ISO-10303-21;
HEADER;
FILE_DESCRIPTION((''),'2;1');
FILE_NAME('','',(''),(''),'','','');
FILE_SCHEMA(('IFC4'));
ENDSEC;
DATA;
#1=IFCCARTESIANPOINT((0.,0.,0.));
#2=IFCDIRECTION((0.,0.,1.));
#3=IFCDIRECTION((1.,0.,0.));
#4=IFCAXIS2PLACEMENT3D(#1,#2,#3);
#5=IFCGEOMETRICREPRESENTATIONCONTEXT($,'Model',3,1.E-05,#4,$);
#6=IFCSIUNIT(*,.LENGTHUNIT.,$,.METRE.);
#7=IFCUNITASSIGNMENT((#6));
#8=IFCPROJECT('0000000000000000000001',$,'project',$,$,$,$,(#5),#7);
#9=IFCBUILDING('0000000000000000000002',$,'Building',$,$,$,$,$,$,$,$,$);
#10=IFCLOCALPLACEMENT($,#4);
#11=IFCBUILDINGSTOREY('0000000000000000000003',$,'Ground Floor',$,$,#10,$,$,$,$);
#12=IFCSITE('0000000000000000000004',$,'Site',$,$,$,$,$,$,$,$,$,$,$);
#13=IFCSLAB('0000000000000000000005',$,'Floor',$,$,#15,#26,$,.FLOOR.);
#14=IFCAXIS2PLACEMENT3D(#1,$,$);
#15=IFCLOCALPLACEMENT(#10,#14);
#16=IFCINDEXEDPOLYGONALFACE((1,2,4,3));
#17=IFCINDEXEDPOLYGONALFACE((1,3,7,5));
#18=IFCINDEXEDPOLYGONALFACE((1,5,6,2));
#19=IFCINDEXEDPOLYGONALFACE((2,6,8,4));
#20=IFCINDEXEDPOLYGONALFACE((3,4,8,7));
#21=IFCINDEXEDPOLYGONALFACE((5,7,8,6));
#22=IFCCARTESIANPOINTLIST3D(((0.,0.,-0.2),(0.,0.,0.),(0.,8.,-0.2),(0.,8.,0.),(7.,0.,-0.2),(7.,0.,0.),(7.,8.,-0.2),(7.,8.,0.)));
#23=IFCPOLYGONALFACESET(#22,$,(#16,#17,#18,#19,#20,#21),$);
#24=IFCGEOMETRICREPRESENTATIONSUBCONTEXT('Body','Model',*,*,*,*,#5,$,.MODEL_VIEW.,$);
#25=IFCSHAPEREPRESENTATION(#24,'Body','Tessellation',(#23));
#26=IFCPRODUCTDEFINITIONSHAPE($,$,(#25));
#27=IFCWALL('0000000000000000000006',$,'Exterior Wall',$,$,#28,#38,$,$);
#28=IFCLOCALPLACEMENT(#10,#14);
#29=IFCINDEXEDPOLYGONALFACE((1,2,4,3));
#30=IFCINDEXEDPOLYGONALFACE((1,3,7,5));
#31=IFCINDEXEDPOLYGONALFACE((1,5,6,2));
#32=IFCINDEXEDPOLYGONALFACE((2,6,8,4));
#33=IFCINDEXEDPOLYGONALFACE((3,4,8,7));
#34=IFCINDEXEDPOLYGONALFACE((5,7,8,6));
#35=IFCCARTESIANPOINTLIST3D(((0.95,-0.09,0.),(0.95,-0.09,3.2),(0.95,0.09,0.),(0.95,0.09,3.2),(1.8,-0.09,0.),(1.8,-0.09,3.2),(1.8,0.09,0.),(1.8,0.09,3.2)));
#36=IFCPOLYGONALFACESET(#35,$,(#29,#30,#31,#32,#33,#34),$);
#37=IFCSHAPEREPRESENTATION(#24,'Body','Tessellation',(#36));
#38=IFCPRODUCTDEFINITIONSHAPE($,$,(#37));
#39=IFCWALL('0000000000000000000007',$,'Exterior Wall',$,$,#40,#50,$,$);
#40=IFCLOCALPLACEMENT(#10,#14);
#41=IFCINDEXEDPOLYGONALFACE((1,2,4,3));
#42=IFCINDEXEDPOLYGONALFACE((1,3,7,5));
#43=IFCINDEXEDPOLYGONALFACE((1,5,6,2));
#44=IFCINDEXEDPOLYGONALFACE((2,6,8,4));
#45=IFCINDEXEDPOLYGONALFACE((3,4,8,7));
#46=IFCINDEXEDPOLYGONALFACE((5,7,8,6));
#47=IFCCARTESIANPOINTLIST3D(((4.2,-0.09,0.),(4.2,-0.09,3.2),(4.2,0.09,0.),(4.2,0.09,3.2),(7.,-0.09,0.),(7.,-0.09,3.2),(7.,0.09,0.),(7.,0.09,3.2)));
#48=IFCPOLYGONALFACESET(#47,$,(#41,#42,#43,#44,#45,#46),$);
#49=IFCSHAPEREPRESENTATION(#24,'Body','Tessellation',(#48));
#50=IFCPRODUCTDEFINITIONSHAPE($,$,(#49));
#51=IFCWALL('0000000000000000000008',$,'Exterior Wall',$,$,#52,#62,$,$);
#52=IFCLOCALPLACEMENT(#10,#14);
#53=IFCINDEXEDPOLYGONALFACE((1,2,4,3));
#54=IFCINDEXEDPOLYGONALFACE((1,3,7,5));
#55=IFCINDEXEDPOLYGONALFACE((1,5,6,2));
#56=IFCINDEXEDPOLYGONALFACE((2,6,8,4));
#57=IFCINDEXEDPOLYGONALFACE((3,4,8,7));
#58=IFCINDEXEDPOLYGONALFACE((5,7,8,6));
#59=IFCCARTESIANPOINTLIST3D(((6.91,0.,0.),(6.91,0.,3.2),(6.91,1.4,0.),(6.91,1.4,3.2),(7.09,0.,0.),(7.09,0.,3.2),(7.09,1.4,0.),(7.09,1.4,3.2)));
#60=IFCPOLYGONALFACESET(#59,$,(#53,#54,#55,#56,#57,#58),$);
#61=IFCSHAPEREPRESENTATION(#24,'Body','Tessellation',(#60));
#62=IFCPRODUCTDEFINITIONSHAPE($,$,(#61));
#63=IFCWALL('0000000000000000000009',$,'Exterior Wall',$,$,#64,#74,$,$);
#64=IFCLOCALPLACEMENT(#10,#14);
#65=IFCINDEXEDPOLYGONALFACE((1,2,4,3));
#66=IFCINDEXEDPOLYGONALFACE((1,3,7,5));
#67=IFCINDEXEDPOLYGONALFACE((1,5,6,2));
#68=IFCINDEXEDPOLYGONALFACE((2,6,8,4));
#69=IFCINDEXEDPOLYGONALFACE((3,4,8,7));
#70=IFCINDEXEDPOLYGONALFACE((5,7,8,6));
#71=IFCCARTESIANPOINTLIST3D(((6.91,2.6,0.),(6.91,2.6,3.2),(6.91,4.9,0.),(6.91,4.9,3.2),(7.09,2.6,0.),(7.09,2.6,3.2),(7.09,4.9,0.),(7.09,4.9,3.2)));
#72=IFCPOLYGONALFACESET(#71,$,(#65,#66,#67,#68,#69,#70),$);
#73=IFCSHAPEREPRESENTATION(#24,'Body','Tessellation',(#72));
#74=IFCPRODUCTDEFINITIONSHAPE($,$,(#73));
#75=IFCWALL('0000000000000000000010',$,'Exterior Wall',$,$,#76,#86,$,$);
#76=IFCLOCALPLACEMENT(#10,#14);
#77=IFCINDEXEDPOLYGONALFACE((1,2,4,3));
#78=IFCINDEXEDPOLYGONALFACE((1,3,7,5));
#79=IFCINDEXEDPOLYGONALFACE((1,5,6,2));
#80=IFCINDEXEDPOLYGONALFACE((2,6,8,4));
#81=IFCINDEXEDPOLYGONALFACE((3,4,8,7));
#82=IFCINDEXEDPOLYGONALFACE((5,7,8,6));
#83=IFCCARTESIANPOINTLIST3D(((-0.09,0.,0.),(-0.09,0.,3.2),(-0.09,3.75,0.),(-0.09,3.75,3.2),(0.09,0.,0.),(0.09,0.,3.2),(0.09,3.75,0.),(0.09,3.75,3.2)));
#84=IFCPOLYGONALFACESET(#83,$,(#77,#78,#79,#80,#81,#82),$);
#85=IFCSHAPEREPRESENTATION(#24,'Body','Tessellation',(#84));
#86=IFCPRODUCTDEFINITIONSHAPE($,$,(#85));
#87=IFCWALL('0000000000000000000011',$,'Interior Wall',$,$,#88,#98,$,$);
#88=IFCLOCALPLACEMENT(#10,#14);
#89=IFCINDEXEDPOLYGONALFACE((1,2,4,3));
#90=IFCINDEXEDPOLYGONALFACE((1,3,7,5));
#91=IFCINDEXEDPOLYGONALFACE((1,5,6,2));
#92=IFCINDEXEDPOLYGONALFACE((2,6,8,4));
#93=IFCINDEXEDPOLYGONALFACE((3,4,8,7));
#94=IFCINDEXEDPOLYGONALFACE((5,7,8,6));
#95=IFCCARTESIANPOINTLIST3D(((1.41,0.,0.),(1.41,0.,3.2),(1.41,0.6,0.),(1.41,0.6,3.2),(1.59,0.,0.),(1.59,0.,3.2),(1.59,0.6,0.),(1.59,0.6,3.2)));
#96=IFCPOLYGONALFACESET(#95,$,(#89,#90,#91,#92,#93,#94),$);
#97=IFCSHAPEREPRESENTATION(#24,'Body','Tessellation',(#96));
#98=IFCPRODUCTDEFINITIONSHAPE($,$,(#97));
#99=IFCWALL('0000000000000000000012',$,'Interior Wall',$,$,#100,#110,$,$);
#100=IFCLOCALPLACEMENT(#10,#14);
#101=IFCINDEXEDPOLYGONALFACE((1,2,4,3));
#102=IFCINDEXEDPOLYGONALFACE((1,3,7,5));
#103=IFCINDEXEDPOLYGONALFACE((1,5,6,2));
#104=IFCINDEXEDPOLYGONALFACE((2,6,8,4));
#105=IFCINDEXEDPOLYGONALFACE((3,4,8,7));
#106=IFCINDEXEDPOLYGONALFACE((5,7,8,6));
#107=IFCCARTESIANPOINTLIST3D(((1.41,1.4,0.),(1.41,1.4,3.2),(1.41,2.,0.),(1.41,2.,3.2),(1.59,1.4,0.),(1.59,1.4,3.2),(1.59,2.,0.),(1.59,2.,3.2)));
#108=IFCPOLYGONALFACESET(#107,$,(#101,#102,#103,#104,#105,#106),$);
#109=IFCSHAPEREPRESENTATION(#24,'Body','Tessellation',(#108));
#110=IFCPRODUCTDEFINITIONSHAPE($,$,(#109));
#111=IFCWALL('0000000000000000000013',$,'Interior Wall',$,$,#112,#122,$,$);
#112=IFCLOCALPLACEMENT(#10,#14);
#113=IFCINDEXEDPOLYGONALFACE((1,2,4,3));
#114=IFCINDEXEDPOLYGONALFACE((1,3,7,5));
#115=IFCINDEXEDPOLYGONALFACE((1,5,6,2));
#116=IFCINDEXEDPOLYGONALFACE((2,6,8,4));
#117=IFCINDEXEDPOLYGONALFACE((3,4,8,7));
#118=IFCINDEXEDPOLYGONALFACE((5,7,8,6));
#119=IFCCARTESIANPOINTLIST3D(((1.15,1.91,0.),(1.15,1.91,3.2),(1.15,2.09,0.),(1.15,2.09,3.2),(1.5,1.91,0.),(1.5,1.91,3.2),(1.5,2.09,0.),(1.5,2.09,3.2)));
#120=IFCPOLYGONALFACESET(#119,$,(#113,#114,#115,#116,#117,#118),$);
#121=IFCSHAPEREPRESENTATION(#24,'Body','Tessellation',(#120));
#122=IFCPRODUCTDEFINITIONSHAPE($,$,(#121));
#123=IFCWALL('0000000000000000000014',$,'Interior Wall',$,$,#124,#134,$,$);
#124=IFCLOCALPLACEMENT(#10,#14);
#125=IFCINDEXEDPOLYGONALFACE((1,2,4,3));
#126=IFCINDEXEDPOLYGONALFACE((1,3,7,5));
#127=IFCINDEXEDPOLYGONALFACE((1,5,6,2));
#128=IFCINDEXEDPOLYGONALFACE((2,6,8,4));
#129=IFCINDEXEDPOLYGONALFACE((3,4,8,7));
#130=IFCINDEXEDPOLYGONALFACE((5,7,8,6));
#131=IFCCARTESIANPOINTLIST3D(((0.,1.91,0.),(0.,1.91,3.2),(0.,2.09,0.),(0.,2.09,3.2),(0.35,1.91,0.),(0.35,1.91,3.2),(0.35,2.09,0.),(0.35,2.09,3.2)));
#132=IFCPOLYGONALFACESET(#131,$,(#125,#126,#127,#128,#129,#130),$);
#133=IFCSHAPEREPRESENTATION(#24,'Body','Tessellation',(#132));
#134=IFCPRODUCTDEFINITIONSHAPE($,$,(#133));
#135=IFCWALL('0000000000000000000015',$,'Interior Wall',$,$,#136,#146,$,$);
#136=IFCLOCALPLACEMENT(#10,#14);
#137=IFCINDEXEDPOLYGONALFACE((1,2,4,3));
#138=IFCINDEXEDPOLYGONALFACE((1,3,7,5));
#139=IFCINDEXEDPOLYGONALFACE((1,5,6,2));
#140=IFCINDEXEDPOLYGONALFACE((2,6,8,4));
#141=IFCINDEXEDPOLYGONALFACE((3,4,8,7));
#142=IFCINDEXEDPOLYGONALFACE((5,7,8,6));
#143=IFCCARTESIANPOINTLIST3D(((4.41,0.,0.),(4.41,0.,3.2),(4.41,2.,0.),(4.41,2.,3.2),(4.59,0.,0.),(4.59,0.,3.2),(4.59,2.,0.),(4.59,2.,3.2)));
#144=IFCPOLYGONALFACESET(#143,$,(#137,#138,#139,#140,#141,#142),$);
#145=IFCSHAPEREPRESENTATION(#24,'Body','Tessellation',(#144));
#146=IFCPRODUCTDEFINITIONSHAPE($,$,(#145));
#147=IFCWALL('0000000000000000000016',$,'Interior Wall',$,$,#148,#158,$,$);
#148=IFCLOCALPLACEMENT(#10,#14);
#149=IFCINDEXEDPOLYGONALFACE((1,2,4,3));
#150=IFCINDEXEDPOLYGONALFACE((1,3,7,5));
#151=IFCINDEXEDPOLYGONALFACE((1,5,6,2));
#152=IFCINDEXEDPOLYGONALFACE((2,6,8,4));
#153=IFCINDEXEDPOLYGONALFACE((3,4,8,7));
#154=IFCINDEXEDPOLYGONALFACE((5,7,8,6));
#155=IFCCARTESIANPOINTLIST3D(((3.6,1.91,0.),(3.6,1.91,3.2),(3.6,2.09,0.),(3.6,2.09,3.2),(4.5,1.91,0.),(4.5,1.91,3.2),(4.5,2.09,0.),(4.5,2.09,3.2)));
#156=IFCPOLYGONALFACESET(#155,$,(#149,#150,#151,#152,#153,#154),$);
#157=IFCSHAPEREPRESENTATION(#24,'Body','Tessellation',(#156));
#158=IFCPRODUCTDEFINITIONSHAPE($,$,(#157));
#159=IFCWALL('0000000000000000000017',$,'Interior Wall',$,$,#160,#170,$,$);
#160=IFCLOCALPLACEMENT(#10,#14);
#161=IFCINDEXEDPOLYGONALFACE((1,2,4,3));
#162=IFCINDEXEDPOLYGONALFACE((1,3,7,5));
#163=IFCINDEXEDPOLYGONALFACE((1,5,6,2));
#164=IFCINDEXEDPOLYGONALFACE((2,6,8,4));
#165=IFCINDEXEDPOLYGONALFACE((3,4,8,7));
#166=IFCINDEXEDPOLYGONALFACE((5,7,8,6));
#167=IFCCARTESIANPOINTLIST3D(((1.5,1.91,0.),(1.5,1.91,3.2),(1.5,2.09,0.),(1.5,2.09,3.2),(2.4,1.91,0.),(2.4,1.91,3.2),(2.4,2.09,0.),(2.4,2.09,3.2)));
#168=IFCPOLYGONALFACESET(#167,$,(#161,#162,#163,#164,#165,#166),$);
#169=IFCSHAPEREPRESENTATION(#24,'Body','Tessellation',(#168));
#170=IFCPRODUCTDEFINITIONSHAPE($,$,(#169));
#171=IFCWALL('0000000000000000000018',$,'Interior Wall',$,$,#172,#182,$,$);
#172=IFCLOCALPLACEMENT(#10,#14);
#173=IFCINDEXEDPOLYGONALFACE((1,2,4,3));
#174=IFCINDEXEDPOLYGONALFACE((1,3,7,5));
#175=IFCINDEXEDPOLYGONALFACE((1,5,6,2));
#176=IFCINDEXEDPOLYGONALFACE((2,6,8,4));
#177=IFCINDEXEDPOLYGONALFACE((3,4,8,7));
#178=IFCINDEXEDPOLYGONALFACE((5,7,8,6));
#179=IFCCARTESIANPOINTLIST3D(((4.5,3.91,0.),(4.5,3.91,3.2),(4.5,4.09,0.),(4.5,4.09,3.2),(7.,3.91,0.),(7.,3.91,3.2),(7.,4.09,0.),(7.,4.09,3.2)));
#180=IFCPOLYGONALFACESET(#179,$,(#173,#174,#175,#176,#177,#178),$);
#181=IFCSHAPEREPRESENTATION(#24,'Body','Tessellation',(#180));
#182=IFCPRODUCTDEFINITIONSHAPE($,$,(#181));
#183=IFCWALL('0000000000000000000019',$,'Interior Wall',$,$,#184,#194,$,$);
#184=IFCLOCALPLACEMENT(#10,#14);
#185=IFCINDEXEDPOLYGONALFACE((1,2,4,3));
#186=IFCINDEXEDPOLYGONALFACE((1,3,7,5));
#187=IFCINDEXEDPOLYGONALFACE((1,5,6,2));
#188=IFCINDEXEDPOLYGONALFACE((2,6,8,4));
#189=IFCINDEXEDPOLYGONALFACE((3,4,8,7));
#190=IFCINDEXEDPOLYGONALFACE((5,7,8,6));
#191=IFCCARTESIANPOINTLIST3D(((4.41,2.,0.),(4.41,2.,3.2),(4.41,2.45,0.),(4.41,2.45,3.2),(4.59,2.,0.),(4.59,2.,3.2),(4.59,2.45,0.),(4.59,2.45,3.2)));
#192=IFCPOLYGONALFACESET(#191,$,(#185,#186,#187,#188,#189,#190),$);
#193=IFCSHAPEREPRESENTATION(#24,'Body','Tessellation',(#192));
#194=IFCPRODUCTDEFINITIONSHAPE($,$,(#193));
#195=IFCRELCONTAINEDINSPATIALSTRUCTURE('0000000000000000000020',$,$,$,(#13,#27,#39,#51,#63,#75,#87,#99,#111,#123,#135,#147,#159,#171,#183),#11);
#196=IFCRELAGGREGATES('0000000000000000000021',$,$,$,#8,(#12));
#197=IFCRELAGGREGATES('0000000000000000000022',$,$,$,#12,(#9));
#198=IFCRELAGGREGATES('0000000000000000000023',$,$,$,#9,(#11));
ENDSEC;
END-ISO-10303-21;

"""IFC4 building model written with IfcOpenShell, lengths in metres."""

from ifc_helpers import new_model, si_unit, frame, origin_with_axes, place, context, subcontext, project, spatial, indexed_curve, outline, extrude, element, save


model = new_model("IFC4")

# Units and contexts
model_context = context("Model", 3, precision=1e-05, world=origin_with_axes())
body_context = subcontext(model_context, "Body", "Model", "MODEL_VIEW")
ifc_project = project(units=[si_unit("LENGTHUNIT", "METRE")], contexts=[model_context])

# Site, building, storey
site = spatial("IfcSite", under=ifc_project, Name="Site")
building = spatial("IfcBuilding", under=site, Name="Building")
storey_placement = place(None, origin_with_axes())
storey = spatial("IfcBuildingStorey", under=building, at=storey_placement, Name="Ground Floor")

# Slab
slab_placement = place(storey_placement, frame((0.0, 0.0, -0.2), z_axis=(0.0, 0.0, 1.0), x_axis=(1.0, 0.0, 0.0)))
element("IfcSlab", 1, at=slab_placement, inside=storey, Name="Floor", PredefinedType="FLOOR", context=body_context, shape_type="SweptSolid", body=[
    extrude(outline(indexed_curve([(0.0, 0.0), (7.0, 0.0), (7.0, 8.0), (0.0, 8.0)])), None, (0.0, 0.0, 1.0), 0.2),
])

# Walls
wall_1_placement = place(storey_placement, frame((0.95, 0.0, 0.0), z_axis=(0.0, 0.0, 1.0), x_axis=(1.0, 0.0, 0.0)))
element("IfcWall", 2, at=wall_1_placement, inside=storey, Name="Exterior Wall", context=body_context, shape_type="SweptSolid", body=[
    extrude(outline(indexed_curve([(0.0, 0.0), (0.0, 0.18), (0.85, 0.18), (0.85, 0.0), (0.0, 0.0)], self_intersect=False)), frame((0.0, -0.09, 0.0), z_axis=(0.0, 0.0, 1.0), x_axis=(1.0, 0.0, 0.0)), (0.0, 0.0, 1.0), 3.2),
])
wall_2_placement = place(storey_placement, frame((4.2, 0.0, 0.0), z_axis=(0.0, 0.0, 1.0), x_axis=(1.0, 0.0, 0.0)))
element("IfcWall", 3, at=wall_2_placement, inside=storey, Name="Exterior Wall", context=body_context, shape_type="SweptSolid", body=[
    extrude(outline(indexed_curve([(0.0, 0.0), (0.0, 0.18), (2.8, 0.18), (2.8, 0.0), (0.0, 0.0)], self_intersect=False)), frame((0.0, -0.09, 0.0), z_axis=(0.0, 0.0, 1.0), x_axis=(1.0, 0.0, 0.0)), (0.0, 0.0, 1.0), 3.2),
])
wall_3_placement = place(storey_placement, frame((7.0, 0.0, 0.0), z_axis=(0.0, 0.0, 1.0), x_axis=(0.0, 1.0, 0.0)))
element("IfcWall", 4, at=wall_3_placement, inside=storey, Name="Exterior Wall", context=body_context, shape_type="SweptSolid", body=[
    extrude(outline(indexed_curve([(0.0, 0.0), (0.0, 0.18), (1.4, 0.18), (1.4, 0.0), (0.0, 0.0)], self_intersect=False)), frame((0.0, -0.09, 0.0), z_axis=(0.0, 0.0, 1.0), x_axis=(1.0, 0.0, 0.0)), (0.0, 0.0, 1.0), 3.2),
])
wall_4_placement = place(storey_placement, frame((7.0, 2.6, 0.0), z_axis=(0.0, 0.0, 1.0), x_axis=(0.0, 1.0, 0.0)))
element("IfcWall", 5, at=wall_4_placement, inside=storey, Name="Exterior Wall", context=body_context, shape_type="SweptSolid", body=[
    extrude(outline(indexed_curve([(0.0, 0.0), (0.0, 0.18), (2.3, 0.18), (2.3, 0.0), (0.0, 0.0)], self_intersect=False)), frame((0.0, -0.09, 0.0), z_axis=(0.0, 0.0, 1.0), x_axis=(1.0, 0.0, 0.0)), (0.0, 0.0, 1.0), 3.2),
])
wall_5_placement = place(storey_placement, frame((0.0, 3.75, 0.0), z_axis=(0.0, 0.0, 1.0), x_axis=(0.0, -1.0, 0.0)))
element("IfcWall", 6, at=wall_5_placement, inside=storey, Name="Exterior Wall", context=body_context, shape_type="SweptSolid", body=[
    extrude(outline(indexed_curve([(0.0, 0.0), (0.0, 0.18), (3.75, 0.18), (3.75, 0.0), (0.0, 0.0)], self_intersect=False)), frame((0.0, -0.09, 0.0), z_axis=(0.0, 0.0, 1.0), x_axis=(1.0, 0.0, 0.0)), (0.0, 0.0, 1.0), 3.2),
])
wall_6_placement = place(storey_placement, frame((1.5, 0.0, 0.0), z_axis=(0.0, 0.0, 1.0), x_axis=(0.0, 1.0, 0.0)))
element("IfcWall", 7, at=wall_6_placement, inside=storey, Name="Interior Wall", context=body_context, shape_type="SweptSolid", body=[
    extrude(outline(indexed_curve([(0.0, 0.0), (0.0, 0.18), (0.6, 0.18), (0.6, 0.0), (0.0, 0.0)], self_intersect=False)), frame((0.0, -0.09, 0.0), z_axis=(0.0, 0.0, 1.0), x_axis=(1.0, 0.0, 0.0)), (0.0, 0.0, 1.0), 3.2),
])
wall_7_placement = place(storey_placement, frame((1.5, 1.4, 0.0), z_axis=(0.0, 0.0, 1.0), x_axis=(0.0, 1.0, 0.0)))
element("IfcWall", 8, at=wall_7_placement, inside=storey, Name="Interior Wall", context=body_context, shape_type="SweptSolid", body=[
    extrude(outline(indexed_curve([(0.0, 0.0), (0.0, 0.18), (0.6, 0.18), (0.6, 0.0), (0.0, 0.0)], self_intersect=False)), frame((0.0, -0.09, 0.0), z_axis=(0.0, 0.0, 1.0), x_axis=(1.0, 0.0, 0.0)), (0.0, 0.0, 1.0), 3.2),
])
for number, where, z_axis, x_axis, name in (
    (9, (1.5, 2.0, 0.0), (0.0, 0.0, 1.0), (-1.0, 0.0, 0.0), "Interior Wall"),
    (10, (0.35, 2.0, 0.0), (0.0, 0.0, 1.0), (-1.0, 0.0, 0.0), "Interior Wall"),
):
    element("IfcWall", number, at=place(storey_placement, frame(where, z_axis=z_axis, x_axis=x_axis)), inside=storey, Name=name, context=body_context, shape_type="SweptSolid", body=[
        extrude(outline(indexed_curve([(0.0, 0.0), (0.0, 0.18), (0.35, 0.18), (0.35, 0.0), (0.0, 0.0)], self_intersect=False)), frame((0.0, -0.09, 0.0), z_axis=(0.0, 0.0, 1.0), x_axis=(1.0, 0.0, 0.0)), (0.0, 0.0, 1.0), 3.2),
    ])
wall_8_placement = place(storey_placement, frame((4.5, 0.0, 0.0), z_axis=(0.0, 0.0, 1.0), x_axis=(0.0, 1.0, 0.0)))
element("IfcWall", 11, at=wall_8_placement, inside=storey, Name="Interior Wall", context=body_context, shape_type="SweptSolid", body=[
    extrude(outline(indexed_curve([(0.0, 0.0), (0.0, 0.18), (2.0, 0.18), (2.0, 0.0), (0.0, 0.0)], self_intersect=False)), frame((0.0, -0.09, 0.0), z_axis=(0.0, 0.0, 1.0), x_axis=(1.0, 0.0, 0.0)), (0.0, 0.0, 1.0), 3.2),
])
for number, where, z_axis, x_axis, name in (
    (12, (4.5, 2.0, 0.0), (0.0, 0.0, 1.0), (-1.0, 0.0, 0.0), "Interior Wall"),
    (13, (2.4, 2.0, 0.0), (0.0, 0.0, 1.0), (-1.0, 0.0, 0.0), "Interior Wall"),
):
    element("IfcWall", number, at=place(storey_placement, frame(where, z_axis=z_axis, x_axis=x_axis)), inside=storey, Name=name, context=body_context, shape_type="SweptSolid", body=[
        extrude(outline(indexed_curve([(0.0, 0.0), (0.0, 0.18), (0.9, 0.18), (0.9, 0.0), (0.0, 0.0)], self_intersect=False)), frame((0.0, -0.09, 0.0), z_axis=(0.0, 0.0, 1.0), x_axis=(1.0, 0.0, 0.0)), (0.0, 0.0, 1.0), 3.2),
    ])
wall_9_placement = place(storey_placement, frame((7.0, 4.0, 0.0), z_axis=(0.0, 0.0, 1.0), x_axis=(-1.0, 0.0, 0.0)))
element("IfcWall", 14, at=wall_9_placement, inside=storey, Name="Interior Wall", context=body_context, shape_type="SweptSolid", body=[
    extrude(outline(indexed_curve([(0.0, 0.0), (0.0, 0.18), (2.5, 0.18), (2.5, 0.0), (0.0, 0.0)], self_intersect=False)), frame((0.0, -0.09, 0.0), z_axis=(0.0, 0.0, 1.0), x_axis=(1.0, 0.0, 0.0)), (0.0, 0.0, 1.0), 3.2),
])
wall_10_placement = place(storey_placement, frame((4.5, 2.45, 0.0), z_axis=(0.0, 0.0, 1.0), x_axis=(0.0, -1.0, 0.0)))
element("IfcWall", 15, at=wall_10_placement, inside=storey, Name="Interior Wall", context=body_context, shape_type="SweptSolid", body=[
    extrude(outline(indexed_curve([(0.0, 0.0), (0.0, 0.18), (0.45, 0.18), (0.45, 0.0), (0.0, 0.0)], self_intersect=False)), frame((0.0, -0.09, 0.0), z_axis=(0.0, 0.0, 1.0), x_axis=(1.0, 0.0, 0.0)), (0.0, 0.0, 1.0), 3.2),
])

save(model, "model.ifc")
